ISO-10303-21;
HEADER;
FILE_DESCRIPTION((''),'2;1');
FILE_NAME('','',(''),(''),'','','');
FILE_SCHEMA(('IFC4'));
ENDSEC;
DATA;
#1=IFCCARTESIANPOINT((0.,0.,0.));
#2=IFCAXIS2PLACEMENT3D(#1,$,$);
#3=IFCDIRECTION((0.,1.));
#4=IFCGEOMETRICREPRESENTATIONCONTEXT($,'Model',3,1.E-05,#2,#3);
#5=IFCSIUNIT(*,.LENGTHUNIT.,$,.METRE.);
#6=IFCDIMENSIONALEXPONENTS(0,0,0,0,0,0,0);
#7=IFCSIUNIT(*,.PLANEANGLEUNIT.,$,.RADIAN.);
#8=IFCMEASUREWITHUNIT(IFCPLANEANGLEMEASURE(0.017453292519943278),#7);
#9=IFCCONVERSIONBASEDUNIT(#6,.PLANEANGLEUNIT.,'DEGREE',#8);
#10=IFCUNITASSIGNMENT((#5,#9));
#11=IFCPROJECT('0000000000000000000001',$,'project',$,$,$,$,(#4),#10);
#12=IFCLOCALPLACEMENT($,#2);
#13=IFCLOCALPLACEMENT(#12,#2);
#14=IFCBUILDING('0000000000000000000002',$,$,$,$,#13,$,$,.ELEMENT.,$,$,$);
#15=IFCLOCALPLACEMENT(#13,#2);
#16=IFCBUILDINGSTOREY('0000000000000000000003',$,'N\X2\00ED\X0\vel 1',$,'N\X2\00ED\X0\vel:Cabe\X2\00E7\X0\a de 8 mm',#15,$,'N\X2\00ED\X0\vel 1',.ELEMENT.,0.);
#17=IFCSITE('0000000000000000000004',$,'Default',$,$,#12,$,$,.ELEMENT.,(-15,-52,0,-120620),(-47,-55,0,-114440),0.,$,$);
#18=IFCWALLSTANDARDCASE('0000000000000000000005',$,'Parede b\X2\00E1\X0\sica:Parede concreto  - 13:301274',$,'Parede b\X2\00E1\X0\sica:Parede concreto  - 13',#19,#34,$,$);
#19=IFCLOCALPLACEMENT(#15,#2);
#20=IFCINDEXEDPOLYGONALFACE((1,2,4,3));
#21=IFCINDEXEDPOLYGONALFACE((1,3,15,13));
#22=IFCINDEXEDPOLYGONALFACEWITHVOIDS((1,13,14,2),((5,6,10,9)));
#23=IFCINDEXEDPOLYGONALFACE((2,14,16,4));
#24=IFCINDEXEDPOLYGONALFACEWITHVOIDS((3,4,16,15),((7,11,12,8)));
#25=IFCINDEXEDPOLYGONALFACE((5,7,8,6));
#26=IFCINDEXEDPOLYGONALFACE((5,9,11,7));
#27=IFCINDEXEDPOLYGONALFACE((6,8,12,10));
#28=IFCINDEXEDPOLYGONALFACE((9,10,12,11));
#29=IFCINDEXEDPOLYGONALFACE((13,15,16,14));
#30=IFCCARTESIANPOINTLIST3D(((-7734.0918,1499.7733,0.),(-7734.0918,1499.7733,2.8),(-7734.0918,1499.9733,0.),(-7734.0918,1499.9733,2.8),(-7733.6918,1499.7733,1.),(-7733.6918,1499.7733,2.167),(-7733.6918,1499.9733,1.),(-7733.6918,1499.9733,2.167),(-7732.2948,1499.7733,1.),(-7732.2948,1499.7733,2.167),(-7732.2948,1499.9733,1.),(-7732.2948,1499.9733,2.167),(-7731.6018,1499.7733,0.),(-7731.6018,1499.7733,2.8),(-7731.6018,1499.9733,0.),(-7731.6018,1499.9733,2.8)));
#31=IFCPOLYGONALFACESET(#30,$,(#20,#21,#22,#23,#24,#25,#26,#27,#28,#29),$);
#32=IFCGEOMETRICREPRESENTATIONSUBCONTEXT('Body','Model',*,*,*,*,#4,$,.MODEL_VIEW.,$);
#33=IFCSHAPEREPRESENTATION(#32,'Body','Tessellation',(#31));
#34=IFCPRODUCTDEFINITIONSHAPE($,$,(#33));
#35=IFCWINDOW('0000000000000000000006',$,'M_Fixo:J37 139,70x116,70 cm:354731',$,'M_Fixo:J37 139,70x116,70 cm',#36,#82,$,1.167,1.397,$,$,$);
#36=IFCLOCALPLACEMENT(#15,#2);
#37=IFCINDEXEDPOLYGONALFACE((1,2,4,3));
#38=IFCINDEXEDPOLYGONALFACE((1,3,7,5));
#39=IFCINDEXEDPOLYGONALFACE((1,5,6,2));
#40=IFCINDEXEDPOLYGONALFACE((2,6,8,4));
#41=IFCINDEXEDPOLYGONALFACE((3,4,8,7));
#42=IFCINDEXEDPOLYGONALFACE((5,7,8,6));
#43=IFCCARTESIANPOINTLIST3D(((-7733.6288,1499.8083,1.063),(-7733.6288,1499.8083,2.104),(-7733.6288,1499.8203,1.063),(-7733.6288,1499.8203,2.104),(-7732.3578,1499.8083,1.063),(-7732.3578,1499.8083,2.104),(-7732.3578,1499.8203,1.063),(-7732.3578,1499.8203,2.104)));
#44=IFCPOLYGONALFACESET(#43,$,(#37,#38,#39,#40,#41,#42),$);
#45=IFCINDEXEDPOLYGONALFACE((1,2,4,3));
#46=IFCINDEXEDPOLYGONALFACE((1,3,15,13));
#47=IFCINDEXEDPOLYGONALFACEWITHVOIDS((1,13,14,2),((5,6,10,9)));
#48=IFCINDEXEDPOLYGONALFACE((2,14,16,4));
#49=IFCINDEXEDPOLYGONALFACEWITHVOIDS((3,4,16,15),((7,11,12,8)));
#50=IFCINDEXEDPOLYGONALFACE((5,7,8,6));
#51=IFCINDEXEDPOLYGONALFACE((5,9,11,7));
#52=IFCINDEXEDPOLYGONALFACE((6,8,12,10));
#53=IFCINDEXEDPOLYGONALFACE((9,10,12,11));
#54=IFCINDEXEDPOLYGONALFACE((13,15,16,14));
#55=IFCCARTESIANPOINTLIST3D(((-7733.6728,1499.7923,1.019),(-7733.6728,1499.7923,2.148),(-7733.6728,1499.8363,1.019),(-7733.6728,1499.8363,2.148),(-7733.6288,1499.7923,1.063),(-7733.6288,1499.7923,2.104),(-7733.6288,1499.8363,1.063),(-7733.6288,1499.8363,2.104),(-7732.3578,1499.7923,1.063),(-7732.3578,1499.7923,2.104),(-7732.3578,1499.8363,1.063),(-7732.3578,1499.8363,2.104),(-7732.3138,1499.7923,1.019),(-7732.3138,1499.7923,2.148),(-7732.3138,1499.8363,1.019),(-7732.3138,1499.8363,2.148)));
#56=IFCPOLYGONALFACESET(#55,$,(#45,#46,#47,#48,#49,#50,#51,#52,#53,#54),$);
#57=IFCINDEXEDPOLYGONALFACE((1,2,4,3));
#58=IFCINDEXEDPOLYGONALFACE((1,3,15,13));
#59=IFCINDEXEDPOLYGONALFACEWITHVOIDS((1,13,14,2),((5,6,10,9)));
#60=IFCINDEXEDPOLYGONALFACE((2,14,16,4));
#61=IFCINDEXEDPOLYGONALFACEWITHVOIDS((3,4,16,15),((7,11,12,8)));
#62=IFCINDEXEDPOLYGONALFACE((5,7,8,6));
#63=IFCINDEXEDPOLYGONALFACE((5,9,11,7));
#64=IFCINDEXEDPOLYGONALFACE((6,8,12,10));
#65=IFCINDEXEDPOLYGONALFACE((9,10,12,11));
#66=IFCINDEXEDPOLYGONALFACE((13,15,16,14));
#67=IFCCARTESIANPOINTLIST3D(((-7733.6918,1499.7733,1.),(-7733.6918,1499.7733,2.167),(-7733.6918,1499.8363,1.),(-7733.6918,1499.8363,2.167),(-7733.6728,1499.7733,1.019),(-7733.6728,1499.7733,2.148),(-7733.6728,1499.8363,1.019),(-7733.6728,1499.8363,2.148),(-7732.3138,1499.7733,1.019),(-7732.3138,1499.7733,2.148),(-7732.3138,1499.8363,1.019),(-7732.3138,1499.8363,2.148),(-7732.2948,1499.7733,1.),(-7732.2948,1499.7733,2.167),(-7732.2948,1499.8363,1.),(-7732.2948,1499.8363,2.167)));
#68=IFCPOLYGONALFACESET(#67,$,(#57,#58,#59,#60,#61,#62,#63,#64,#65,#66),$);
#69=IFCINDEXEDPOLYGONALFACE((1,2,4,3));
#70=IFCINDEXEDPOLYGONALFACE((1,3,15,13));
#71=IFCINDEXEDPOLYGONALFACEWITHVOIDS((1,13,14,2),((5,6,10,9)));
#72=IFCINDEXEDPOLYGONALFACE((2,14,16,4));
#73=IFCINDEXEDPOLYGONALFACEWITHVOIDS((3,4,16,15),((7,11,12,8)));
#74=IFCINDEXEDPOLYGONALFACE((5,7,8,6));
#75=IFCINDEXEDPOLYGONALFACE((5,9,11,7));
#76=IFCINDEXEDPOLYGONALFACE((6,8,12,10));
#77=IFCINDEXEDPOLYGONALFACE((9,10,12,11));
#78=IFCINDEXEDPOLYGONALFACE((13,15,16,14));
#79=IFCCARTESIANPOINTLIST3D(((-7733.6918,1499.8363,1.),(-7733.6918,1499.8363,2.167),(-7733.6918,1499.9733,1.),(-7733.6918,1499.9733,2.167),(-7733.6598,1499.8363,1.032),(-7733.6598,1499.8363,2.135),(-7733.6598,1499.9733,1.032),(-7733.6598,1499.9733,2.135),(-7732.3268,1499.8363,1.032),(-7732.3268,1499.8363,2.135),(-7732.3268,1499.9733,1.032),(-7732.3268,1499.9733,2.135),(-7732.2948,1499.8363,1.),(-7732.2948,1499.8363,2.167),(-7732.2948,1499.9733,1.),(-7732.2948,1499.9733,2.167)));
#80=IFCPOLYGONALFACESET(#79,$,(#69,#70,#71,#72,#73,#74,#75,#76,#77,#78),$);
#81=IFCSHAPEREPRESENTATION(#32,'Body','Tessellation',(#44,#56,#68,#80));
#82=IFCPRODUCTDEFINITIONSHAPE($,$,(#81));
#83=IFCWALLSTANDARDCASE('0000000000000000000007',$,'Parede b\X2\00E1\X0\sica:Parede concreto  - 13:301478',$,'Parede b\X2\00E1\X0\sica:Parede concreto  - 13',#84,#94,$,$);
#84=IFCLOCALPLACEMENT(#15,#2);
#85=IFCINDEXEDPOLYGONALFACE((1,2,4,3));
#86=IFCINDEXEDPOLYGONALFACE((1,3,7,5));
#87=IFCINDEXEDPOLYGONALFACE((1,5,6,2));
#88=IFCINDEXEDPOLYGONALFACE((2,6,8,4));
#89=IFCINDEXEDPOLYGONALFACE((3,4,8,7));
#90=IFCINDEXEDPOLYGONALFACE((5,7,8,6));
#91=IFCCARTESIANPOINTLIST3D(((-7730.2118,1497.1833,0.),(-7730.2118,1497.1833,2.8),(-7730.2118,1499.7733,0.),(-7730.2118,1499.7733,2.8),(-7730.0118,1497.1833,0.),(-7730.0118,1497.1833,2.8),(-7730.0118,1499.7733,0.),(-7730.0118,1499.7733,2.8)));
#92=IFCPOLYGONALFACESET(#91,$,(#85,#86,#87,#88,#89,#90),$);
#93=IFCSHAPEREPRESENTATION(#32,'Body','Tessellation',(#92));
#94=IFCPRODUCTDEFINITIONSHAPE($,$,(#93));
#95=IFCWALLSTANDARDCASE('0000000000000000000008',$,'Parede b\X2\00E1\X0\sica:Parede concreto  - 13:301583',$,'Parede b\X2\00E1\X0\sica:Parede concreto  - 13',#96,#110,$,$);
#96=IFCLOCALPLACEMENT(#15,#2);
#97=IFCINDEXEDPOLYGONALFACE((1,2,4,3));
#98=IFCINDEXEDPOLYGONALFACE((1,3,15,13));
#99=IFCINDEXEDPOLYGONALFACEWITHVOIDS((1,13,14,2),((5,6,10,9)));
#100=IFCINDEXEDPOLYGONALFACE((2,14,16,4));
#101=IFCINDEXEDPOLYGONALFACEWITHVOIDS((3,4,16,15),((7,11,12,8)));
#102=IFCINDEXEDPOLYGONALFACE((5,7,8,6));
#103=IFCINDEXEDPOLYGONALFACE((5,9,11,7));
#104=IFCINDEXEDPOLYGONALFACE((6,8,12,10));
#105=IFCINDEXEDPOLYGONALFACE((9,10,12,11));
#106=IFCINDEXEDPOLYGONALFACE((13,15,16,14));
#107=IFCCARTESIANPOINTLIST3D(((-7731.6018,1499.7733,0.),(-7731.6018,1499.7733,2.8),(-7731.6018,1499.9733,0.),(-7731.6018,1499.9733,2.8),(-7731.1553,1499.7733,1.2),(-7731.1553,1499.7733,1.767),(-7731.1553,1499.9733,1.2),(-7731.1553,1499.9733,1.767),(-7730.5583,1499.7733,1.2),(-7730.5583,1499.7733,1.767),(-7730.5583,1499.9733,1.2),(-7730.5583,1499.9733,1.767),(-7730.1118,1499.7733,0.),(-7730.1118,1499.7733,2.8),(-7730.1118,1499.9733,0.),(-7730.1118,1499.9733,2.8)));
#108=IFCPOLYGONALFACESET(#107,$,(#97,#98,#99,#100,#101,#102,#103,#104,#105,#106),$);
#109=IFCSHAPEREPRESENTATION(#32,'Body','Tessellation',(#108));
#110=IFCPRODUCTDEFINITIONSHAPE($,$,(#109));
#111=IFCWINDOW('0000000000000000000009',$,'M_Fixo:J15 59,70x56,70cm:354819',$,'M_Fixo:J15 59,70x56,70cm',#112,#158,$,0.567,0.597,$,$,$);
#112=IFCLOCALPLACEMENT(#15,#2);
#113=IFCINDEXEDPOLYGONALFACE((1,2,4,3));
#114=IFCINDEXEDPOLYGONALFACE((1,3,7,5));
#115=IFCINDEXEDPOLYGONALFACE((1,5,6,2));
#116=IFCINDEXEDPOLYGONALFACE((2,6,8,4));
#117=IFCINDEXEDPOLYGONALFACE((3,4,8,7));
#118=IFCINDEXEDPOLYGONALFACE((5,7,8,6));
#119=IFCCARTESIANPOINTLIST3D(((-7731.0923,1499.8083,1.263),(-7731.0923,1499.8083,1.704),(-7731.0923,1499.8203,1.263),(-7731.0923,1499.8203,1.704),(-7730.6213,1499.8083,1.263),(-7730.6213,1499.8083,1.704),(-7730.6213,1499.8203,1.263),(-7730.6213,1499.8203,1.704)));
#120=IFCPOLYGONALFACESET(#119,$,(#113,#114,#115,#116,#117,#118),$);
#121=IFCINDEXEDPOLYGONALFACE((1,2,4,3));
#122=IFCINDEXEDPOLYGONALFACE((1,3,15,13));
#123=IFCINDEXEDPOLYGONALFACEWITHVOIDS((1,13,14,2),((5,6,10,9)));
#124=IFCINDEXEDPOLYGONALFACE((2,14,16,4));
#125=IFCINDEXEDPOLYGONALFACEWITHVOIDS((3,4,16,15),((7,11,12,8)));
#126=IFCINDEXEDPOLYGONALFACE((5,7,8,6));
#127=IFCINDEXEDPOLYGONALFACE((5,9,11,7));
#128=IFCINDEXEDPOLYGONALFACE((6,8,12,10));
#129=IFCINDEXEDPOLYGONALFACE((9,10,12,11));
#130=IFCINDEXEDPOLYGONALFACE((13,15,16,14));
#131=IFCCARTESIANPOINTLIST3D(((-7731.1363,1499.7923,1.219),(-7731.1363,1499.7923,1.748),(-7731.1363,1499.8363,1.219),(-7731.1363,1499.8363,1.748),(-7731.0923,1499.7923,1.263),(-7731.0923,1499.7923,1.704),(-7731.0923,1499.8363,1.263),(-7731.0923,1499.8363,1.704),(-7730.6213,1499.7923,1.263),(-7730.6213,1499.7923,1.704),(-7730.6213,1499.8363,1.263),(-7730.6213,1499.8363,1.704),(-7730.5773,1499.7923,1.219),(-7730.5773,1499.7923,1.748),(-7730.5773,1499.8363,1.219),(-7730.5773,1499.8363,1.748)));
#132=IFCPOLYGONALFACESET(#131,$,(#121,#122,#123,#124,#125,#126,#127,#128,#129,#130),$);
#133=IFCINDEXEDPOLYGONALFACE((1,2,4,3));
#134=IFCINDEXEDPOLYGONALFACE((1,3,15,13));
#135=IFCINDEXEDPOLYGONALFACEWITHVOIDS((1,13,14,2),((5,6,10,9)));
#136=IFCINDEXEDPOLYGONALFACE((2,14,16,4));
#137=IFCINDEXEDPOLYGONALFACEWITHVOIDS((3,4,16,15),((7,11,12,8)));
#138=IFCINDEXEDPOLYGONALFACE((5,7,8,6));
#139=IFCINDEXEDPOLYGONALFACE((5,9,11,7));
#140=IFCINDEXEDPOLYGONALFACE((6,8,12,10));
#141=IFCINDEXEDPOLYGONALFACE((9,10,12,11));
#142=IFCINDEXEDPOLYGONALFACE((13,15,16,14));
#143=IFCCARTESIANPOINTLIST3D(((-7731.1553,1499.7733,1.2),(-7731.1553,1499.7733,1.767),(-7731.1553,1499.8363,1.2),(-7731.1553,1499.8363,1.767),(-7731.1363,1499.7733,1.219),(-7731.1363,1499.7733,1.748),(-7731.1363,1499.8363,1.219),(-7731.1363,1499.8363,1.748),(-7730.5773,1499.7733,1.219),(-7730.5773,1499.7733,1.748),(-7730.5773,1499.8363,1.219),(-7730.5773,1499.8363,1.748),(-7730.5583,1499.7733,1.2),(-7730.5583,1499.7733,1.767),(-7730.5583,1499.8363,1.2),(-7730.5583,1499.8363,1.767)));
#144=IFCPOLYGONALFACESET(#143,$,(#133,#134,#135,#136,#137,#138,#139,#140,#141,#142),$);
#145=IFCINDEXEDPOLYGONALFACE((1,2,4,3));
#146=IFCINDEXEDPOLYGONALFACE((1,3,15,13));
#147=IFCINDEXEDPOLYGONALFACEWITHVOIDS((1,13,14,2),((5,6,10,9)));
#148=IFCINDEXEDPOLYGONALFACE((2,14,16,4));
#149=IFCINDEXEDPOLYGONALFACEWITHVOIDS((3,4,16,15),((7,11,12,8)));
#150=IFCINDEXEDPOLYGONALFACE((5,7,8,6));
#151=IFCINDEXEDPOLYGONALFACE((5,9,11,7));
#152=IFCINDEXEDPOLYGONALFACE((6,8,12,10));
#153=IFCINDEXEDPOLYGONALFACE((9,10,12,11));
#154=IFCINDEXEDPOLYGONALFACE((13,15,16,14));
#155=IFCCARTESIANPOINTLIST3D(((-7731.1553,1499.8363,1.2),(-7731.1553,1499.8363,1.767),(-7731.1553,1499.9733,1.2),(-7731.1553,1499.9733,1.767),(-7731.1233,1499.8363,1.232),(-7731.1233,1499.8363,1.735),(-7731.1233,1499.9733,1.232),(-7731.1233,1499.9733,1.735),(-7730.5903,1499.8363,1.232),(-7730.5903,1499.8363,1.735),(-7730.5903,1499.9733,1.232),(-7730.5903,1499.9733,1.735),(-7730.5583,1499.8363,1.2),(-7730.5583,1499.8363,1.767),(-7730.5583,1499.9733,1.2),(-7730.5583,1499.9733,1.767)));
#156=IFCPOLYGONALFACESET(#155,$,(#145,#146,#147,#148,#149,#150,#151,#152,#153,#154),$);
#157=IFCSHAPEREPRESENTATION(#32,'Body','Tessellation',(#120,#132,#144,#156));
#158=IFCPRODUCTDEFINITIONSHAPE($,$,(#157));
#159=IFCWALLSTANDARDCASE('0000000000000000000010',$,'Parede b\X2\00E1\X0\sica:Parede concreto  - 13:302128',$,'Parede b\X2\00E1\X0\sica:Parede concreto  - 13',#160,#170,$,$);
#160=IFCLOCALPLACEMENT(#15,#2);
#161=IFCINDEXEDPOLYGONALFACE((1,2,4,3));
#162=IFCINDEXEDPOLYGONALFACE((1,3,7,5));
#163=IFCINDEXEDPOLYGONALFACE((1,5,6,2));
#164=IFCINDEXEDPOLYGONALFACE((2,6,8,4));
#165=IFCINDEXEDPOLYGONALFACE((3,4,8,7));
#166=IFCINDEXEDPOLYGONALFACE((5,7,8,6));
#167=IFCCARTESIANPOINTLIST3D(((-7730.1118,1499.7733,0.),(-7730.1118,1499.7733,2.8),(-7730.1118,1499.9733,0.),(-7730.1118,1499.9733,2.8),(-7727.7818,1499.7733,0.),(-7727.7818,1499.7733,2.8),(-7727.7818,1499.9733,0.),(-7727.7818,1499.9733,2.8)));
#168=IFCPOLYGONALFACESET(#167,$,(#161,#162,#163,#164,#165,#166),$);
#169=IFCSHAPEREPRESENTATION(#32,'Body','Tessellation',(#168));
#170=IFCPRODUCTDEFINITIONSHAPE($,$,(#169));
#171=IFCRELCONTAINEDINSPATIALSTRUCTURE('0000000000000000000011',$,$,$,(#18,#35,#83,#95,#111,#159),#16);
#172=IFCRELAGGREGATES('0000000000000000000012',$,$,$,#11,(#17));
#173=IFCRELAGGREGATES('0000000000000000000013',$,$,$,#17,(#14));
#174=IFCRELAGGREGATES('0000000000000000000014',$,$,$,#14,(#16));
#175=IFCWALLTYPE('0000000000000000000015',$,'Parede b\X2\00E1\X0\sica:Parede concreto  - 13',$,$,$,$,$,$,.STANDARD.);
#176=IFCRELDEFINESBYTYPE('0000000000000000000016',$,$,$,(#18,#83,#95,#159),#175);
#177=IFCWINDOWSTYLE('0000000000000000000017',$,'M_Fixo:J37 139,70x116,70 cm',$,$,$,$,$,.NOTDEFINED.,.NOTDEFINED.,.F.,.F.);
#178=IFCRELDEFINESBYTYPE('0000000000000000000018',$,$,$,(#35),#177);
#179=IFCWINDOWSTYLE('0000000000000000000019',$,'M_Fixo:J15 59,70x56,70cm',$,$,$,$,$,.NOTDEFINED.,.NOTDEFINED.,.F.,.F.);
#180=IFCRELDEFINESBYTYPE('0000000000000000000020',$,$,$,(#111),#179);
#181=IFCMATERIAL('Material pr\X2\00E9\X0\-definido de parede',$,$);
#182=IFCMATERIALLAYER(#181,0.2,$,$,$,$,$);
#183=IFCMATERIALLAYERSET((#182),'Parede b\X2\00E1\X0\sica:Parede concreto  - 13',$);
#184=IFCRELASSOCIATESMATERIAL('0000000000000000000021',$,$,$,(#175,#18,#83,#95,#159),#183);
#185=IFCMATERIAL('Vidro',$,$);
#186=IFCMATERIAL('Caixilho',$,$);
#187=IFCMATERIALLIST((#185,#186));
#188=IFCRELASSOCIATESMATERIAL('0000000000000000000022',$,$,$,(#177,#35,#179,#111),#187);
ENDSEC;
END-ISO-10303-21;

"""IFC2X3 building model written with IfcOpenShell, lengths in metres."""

from ifc_helpers import new_model, entity, si_unit, converted_unit, direction, frame, frame_2d, origin, place, context, subcontext, project, spatial, polyline, rectangle, outline, extrude, source, transform, mapped, material, material_list, layer, layer_set, layer_usage, type_object, type_shapes, element, fill, save


model = new_model("IFC2X3")

# Units and contexts
model_context = context("Model", 3, precision=1e-05, world=origin(), true_north=direction((0.0, 1.0)))
body_context = subcontext(model_context, "Body", "Model", "MODEL_VIEW")
ifc_project = project(units=[si_unit("LENGTHUNIT", "METRE"), converted_unit("PLANEANGLEUNIT", "DEGREE", entity("IfcPlaneAngleMeasure", 0.017453292519943278), si_unit("PLANEANGLEUNIT", "RADIAN"), dimensions=[0, 0, 0, 0, 0, 0, 0])], contexts=[model_context])

# Site, building, storey
site_placement = place(None, origin())
site = spatial("IfcSite", under=ifc_project, at=site_placement, Name="Default", CompositionType="ELEMENT", RefLatitude=(-15, -52, 0, -120620), RefLongitude=(-47, -55, 0, -114440), RefElevation=0.0)
building_placement = place(site_placement, origin())
building = spatial("IfcBuilding", under=site, at=building_placement, CompositionType="ELEMENT")
storey_placement = place(building_placement, origin())
storey = spatial("IfcBuildingStorey", under=building, at=storey_placement, Name="Nível 1", ObjectType="Nível:Cabeça de 8 mm", LongName="Nível 1", CompositionType="ELEMENT", Elevation=0.0)

# Shared definitions
ifc_material_1 = material(Name="Material pré-definido de parede")
ifc_layer = layer(ifc_material_1, 0.2)
ifc_layer_set = layer_set([ifc_layer], Name="Parede básica:Parede concreto  - 13")
wall_type = type_object("IfcWallType", Name="Parede básica:Parede concreto  - 13", PredefinedType="STANDARD", material=ifc_layer_set)
ifc_material_2 = material(Name="Vidro")
ifc_material_3 = material(Name="Caixilho")
ifc_material_list = material_list([ifc_material_2, ifc_material_3])

# Wall, opening, window
ifc_layer_usage_1 = layer_usage(ifc_layer_set, "AXIS2", "NEGATIVE", 0.1)
wall_1_placement = place(storey_placement, frame((-7734.0918, 1499.8733, 0.0)))
wall_1 = element("IfcWallStandardCase", 1, at=wall_1_placement, inside=storey, type_object=wall_type, material=ifc_layer_usage_1, Name="Parede básica:Parede concreto  - 13:301274", ObjectType="Parede básica:Parede concreto  - 13", context=body_context, shape_type="SweptSolid", body=[
    extrude(rectangle(XDim=2.49, YDim=0.2, at=frame_2d((1.245, 0.0), x_axis=(-1.0, 0.0))), origin(), (0.0, 0.0, 1.0), 2.8),
])
opening_1_placement = place(wall_1_placement, frame((1.797, 0.1, 1.0)))
opening_1 = element("IfcOpeningElement", 2, at=opening_1_placement, cuts=wall_1, ObjectType="Opening", context=body_context, shape_type="SweptSolid", body=[
    extrude(rectangle(XDim=1.167, YDim=1.397, at=frame_2d((0.5835, 0.6985), x_axis=(1.0, 0.0))), frame((0.0, 0.0, 0.0), z_axis=(0.0, -1.0, 0.0), x_axis=(0.0, 0.0, 1.0)), (0.0, 0.0, 1.0), 0.2),
])
window_style_1 = type_object("IfcWindowStyle", Name="M_Fixo:J37 139,70x116,70 cm", ConstructionType="NOTDEFINED", OperationType="NOTDEFINED", ParameterTakesPrecedence=False, Sizeable=False, material=ifc_material_list)
shared_shape_1 = source(origin(), body_context, "Body", "SweptSolid", [
    extrude(rectangle(XDim=0.012, YDim=1.271, at=frame_2d((0.0, 0.0), x_axis=(1.0, 0.0))), frame((0.6985, 0.159, 0.063), z_axis=(0.0, 0.0, 1.0), x_axis=(0.0, -1.0, 0.0)), (0.0, 0.0, 1.0), 1.041),
    extrude(outline(polyline([(-0.6795, -0.5645), (0.6795, -0.5645), (0.6795, 0.5645), (-0.6795, 0.5645), (-0.6795, -0.5645)]), holes=[polyline([(-0.6355, -0.5205), (-0.6355, 0.5205), (0.6355, 0.5205), (0.6355, -0.5205), (-0.6355, -0.5205)])]), frame((0.6985, 0.137, 0.5835), z_axis=(0.0, 1.0, 0.0), x_axis=(1.0, 0.0, 0.0)), (0.0, 0.0, 1.0), 0.044),
    extrude(outline(polyline([(-0.6985, -0.5835), (0.6985, -0.5835), (0.6985, 0.5835), (-0.6985, 0.5835), (-0.6985, -0.5835)]), holes=[polyline([(-0.6795, -0.5645), (-0.6795, 0.5645), (0.6795, 0.5645), (0.6795, -0.5645), (-0.6795, -0.5645)])]), frame((0.6985, 0.137, 0.5835), z_axis=(0.0, 1.0, 0.0), x_axis=(1.0, 0.0, 0.0)), (0.0, 0.0, 1.0), 0.063),
    extrude(outline(polyline([(-0.6985, -0.5835), (0.6985, -0.5835), (0.6985, 0.5835), (-0.6985, 0.5835), (-0.6985, -0.5835)]), holes=[polyline([(-0.6665, -0.5515), (-0.6665, 0.5515), (0.6665, 0.5515), (0.6665, -0.5515), (-0.6665, -0.5515)])]), frame((0.6985, 0.0, 0.5835), z_axis=(0.0, 1.0, 0.0), x_axis=(1.0, 0.0, 0.0)), (0.0, 0.0, 1.0), 0.137),
])
type_shapes(window_style_1, [shared_shape_1])
window_1_placement = place(opening_1_placement, frame((0.0, 0.0, 0.0), z_axis=(0.0, 0.0, 1.0), x_axis=(-1.0, 0.0, 0.0)))
window_1 = element("IfcWindow", 3, at=window_1_placement, inside=storey, type_object=window_style_1, material=ifc_material_list, Name="M_Fixo:J37 139,70x116,70 cm:354731", ObjectType="M_Fixo:J37 139,70x116,70 cm", OverallHeight=1.167, OverallWidth=1.397, context=body_context, shape_type="MappedRepresentation", body=[
    mapped(shared_shape_1, transform((0.0, 0.0, 0.0), scale=1.0)),
])
fill(opening_1, window_1)

# Wall
ifc_layer_usage_2 = layer_usage(ifc_layer_set, "AXIS2", "NEGATIVE", 0.1)
wall_2_placement = place(storey_placement, frame((-7730.1118, 1497.1833, 0.0), z_axis=(0.0, 0.0, 1.0), x_axis=(0.0, 1.0, 0.0)))
element("IfcWallStandardCase", 4, at=wall_2_placement, inside=storey, type_object=wall_type, material=ifc_layer_usage_2, Name="Parede básica:Parede concreto  - 13:301478", ObjectType="Parede básica:Parede concreto  - 13", context=body_context, shape_type="SweptSolid", body=[
    extrude(rectangle(XDim=2.59, YDim=0.2, at=frame_2d((1.295, 0.0), x_axis=(-1.0, 0.0))), origin(), (0.0, 0.0, 1.0), 2.8),
])

# Wall, opening, window
ifc_layer_usage_3 = layer_usage(ifc_layer_set, "AXIS2", "NEGATIVE", 0.1)
wall_3_placement = place(storey_placement, frame((-7730.1118, 1499.8733, 0.0), z_axis=(0.0, 0.0, 1.0), x_axis=(-1.0, 0.0, 0.0)))
wall_3 = element("IfcWallStandardCase", 5, at=wall_3_placement, inside=storey, type_object=wall_type, material=ifc_layer_usage_3, Name="Parede básica:Parede concreto  - 13:301583", ObjectType="Parede básica:Parede concreto  - 13", context=body_context, shape_type="SweptSolid", body=[
    extrude(rectangle(XDim=1.49, YDim=0.2, at=frame_2d((0.745, 0.0), x_axis=(-1.0, 0.0))), origin(), (0.0, 0.0, 1.0), 2.8),
])
opening_2_placement = place(wall_3_placement, frame((0.4465, -0.1, 1.2)))
opening_2 = element("IfcOpeningElement", 6, at=opening_2_placement, cuts=wall_3, ObjectType="Opening", context=body_context, shape_type="SweptSolid", body=[
    extrude(rectangle(XDim=0.567, YDim=0.597, at=frame_2d((0.2835, 0.2985), x_axis=(1.0, 0.0))), frame((0.0, 0.0, 0.0), z_axis=(0.0, 1.0, 0.0), x_axis=(0.0, 0.0, 1.0)), (0.0, 0.0, 1.0), 0.2),
])
window_style_2 = type_object("IfcWindowStyle", Name="M_Fixo:J15 59,70x56,70cm", ConstructionType="NOTDEFINED", OperationType="NOTDEFINED", ParameterTakesPrecedence=False, Sizeable=False, material=ifc_material_list)
shared_shape_2 = source(origin(), body_context, "Body", "SweptSolid", [
    extrude(rectangle(XDim=0.012, YDim=0.471, at=frame_2d((0.0, 0.0), x_axis=(1.0, 0.0))), frame((0.2985, 0.159, 0.063), z_axis=(0.0, 0.0, 1.0), x_axis=(0.0, -1.0, 0.0)), (0.0, 0.0, 1.0), 0.441),
    extrude(outline(polyline([(-0.2795, -0.2645), (0.2795, -0.2645), (0.2795, 0.2645), (-0.2795, 0.2645), (-0.2795, -0.2645)]), holes=[polyline([(-0.2355, -0.2205), (-0.2355, 0.2205), (0.2355, 0.2205), (0.2355, -0.2205), (-0.2355, -0.2205)])]), frame((0.2985, 0.137, 0.2835), z_axis=(0.0, 1.0, 0.0), x_axis=(1.0, 0.0, 0.0)), (0.0, 0.0, 1.0), 0.044),
    extrude(outline(polyline([(-0.2985, -0.2835), (0.2985, -0.2835), (0.2985, 0.2835), (-0.2985, 0.2835), (-0.2985, -0.2835)]), holes=[polyline([(-0.2795, -0.2645), (-0.2795, 0.2645), (0.2795, 0.2645), (0.2795, -0.2645), (-0.2795, -0.2645)])]), frame((0.2985, 0.137, 0.2835), z_axis=(0.0, 1.0, 0.0), x_axis=(1.0, 0.0, 0.0)), (0.0, 0.0, 1.0), 0.063),
    extrude(outline(polyline([(-0.2985, -0.2835), (0.2985, -0.2835), (0.2985, 0.2835), (-0.2985, 0.2835), (-0.2985, -0.2835)]), holes=[polyline([(-0.2665, -0.2515), (-0.2665, 0.2515), (0.2665, 0.2515), (0.2665, -0.2515), (-0.2665, -0.2515)])]), frame((0.2985, 0.0, 0.2835), z_axis=(0.0, 1.0, 0.0), x_axis=(1.0, 0.0, 0.0)), (0.0, 0.0, 1.0), 0.137),
])
type_shapes(window_style_2, [shared_shape_2])
window_2_placement = place(opening_2_placement, origin())
window_2 = element("IfcWindow", 7, at=window_2_placement, inside=storey, type_object=window_style_2, material=ifc_material_list, Name="M_Fixo:J15 59,70x56,70cm:354819", ObjectType="M_Fixo:J15 59,70x56,70cm", OverallHeight=0.567, OverallWidth=0.597, context=body_context, shape_type="MappedRepresentation", body=[
    mapped(shared_shape_2, transform((0.0, 0.0, 0.0), scale=1.0)),
])
fill(opening_2, window_2)

# Wall
ifc_layer_usage_4 = layer_usage(ifc_layer_set, "AXIS2", "POSITIVE", -0.1)
wall_4_placement = place(storey_placement, frame((-7730.1118, 1499.8733, 0.0)))
element("IfcWallStandardCase", 8, at=wall_4_placement, inside=storey, type_object=wall_type, material=ifc_layer_usage_4, Name="Parede básica:Parede concreto  - 13:302128", ObjectType="Parede básica:Parede concreto  - 13", context=body_context, shape_type="SweptSolid", body=[
    extrude(rectangle(XDim=2.33, YDim=0.2, at=frame_2d((1.165, 0.0), x_axis=(-1.0, 0.0))), origin(), (0.0, 0.0, 1.0), 2.8),
])

save(model, "model.ifc")
